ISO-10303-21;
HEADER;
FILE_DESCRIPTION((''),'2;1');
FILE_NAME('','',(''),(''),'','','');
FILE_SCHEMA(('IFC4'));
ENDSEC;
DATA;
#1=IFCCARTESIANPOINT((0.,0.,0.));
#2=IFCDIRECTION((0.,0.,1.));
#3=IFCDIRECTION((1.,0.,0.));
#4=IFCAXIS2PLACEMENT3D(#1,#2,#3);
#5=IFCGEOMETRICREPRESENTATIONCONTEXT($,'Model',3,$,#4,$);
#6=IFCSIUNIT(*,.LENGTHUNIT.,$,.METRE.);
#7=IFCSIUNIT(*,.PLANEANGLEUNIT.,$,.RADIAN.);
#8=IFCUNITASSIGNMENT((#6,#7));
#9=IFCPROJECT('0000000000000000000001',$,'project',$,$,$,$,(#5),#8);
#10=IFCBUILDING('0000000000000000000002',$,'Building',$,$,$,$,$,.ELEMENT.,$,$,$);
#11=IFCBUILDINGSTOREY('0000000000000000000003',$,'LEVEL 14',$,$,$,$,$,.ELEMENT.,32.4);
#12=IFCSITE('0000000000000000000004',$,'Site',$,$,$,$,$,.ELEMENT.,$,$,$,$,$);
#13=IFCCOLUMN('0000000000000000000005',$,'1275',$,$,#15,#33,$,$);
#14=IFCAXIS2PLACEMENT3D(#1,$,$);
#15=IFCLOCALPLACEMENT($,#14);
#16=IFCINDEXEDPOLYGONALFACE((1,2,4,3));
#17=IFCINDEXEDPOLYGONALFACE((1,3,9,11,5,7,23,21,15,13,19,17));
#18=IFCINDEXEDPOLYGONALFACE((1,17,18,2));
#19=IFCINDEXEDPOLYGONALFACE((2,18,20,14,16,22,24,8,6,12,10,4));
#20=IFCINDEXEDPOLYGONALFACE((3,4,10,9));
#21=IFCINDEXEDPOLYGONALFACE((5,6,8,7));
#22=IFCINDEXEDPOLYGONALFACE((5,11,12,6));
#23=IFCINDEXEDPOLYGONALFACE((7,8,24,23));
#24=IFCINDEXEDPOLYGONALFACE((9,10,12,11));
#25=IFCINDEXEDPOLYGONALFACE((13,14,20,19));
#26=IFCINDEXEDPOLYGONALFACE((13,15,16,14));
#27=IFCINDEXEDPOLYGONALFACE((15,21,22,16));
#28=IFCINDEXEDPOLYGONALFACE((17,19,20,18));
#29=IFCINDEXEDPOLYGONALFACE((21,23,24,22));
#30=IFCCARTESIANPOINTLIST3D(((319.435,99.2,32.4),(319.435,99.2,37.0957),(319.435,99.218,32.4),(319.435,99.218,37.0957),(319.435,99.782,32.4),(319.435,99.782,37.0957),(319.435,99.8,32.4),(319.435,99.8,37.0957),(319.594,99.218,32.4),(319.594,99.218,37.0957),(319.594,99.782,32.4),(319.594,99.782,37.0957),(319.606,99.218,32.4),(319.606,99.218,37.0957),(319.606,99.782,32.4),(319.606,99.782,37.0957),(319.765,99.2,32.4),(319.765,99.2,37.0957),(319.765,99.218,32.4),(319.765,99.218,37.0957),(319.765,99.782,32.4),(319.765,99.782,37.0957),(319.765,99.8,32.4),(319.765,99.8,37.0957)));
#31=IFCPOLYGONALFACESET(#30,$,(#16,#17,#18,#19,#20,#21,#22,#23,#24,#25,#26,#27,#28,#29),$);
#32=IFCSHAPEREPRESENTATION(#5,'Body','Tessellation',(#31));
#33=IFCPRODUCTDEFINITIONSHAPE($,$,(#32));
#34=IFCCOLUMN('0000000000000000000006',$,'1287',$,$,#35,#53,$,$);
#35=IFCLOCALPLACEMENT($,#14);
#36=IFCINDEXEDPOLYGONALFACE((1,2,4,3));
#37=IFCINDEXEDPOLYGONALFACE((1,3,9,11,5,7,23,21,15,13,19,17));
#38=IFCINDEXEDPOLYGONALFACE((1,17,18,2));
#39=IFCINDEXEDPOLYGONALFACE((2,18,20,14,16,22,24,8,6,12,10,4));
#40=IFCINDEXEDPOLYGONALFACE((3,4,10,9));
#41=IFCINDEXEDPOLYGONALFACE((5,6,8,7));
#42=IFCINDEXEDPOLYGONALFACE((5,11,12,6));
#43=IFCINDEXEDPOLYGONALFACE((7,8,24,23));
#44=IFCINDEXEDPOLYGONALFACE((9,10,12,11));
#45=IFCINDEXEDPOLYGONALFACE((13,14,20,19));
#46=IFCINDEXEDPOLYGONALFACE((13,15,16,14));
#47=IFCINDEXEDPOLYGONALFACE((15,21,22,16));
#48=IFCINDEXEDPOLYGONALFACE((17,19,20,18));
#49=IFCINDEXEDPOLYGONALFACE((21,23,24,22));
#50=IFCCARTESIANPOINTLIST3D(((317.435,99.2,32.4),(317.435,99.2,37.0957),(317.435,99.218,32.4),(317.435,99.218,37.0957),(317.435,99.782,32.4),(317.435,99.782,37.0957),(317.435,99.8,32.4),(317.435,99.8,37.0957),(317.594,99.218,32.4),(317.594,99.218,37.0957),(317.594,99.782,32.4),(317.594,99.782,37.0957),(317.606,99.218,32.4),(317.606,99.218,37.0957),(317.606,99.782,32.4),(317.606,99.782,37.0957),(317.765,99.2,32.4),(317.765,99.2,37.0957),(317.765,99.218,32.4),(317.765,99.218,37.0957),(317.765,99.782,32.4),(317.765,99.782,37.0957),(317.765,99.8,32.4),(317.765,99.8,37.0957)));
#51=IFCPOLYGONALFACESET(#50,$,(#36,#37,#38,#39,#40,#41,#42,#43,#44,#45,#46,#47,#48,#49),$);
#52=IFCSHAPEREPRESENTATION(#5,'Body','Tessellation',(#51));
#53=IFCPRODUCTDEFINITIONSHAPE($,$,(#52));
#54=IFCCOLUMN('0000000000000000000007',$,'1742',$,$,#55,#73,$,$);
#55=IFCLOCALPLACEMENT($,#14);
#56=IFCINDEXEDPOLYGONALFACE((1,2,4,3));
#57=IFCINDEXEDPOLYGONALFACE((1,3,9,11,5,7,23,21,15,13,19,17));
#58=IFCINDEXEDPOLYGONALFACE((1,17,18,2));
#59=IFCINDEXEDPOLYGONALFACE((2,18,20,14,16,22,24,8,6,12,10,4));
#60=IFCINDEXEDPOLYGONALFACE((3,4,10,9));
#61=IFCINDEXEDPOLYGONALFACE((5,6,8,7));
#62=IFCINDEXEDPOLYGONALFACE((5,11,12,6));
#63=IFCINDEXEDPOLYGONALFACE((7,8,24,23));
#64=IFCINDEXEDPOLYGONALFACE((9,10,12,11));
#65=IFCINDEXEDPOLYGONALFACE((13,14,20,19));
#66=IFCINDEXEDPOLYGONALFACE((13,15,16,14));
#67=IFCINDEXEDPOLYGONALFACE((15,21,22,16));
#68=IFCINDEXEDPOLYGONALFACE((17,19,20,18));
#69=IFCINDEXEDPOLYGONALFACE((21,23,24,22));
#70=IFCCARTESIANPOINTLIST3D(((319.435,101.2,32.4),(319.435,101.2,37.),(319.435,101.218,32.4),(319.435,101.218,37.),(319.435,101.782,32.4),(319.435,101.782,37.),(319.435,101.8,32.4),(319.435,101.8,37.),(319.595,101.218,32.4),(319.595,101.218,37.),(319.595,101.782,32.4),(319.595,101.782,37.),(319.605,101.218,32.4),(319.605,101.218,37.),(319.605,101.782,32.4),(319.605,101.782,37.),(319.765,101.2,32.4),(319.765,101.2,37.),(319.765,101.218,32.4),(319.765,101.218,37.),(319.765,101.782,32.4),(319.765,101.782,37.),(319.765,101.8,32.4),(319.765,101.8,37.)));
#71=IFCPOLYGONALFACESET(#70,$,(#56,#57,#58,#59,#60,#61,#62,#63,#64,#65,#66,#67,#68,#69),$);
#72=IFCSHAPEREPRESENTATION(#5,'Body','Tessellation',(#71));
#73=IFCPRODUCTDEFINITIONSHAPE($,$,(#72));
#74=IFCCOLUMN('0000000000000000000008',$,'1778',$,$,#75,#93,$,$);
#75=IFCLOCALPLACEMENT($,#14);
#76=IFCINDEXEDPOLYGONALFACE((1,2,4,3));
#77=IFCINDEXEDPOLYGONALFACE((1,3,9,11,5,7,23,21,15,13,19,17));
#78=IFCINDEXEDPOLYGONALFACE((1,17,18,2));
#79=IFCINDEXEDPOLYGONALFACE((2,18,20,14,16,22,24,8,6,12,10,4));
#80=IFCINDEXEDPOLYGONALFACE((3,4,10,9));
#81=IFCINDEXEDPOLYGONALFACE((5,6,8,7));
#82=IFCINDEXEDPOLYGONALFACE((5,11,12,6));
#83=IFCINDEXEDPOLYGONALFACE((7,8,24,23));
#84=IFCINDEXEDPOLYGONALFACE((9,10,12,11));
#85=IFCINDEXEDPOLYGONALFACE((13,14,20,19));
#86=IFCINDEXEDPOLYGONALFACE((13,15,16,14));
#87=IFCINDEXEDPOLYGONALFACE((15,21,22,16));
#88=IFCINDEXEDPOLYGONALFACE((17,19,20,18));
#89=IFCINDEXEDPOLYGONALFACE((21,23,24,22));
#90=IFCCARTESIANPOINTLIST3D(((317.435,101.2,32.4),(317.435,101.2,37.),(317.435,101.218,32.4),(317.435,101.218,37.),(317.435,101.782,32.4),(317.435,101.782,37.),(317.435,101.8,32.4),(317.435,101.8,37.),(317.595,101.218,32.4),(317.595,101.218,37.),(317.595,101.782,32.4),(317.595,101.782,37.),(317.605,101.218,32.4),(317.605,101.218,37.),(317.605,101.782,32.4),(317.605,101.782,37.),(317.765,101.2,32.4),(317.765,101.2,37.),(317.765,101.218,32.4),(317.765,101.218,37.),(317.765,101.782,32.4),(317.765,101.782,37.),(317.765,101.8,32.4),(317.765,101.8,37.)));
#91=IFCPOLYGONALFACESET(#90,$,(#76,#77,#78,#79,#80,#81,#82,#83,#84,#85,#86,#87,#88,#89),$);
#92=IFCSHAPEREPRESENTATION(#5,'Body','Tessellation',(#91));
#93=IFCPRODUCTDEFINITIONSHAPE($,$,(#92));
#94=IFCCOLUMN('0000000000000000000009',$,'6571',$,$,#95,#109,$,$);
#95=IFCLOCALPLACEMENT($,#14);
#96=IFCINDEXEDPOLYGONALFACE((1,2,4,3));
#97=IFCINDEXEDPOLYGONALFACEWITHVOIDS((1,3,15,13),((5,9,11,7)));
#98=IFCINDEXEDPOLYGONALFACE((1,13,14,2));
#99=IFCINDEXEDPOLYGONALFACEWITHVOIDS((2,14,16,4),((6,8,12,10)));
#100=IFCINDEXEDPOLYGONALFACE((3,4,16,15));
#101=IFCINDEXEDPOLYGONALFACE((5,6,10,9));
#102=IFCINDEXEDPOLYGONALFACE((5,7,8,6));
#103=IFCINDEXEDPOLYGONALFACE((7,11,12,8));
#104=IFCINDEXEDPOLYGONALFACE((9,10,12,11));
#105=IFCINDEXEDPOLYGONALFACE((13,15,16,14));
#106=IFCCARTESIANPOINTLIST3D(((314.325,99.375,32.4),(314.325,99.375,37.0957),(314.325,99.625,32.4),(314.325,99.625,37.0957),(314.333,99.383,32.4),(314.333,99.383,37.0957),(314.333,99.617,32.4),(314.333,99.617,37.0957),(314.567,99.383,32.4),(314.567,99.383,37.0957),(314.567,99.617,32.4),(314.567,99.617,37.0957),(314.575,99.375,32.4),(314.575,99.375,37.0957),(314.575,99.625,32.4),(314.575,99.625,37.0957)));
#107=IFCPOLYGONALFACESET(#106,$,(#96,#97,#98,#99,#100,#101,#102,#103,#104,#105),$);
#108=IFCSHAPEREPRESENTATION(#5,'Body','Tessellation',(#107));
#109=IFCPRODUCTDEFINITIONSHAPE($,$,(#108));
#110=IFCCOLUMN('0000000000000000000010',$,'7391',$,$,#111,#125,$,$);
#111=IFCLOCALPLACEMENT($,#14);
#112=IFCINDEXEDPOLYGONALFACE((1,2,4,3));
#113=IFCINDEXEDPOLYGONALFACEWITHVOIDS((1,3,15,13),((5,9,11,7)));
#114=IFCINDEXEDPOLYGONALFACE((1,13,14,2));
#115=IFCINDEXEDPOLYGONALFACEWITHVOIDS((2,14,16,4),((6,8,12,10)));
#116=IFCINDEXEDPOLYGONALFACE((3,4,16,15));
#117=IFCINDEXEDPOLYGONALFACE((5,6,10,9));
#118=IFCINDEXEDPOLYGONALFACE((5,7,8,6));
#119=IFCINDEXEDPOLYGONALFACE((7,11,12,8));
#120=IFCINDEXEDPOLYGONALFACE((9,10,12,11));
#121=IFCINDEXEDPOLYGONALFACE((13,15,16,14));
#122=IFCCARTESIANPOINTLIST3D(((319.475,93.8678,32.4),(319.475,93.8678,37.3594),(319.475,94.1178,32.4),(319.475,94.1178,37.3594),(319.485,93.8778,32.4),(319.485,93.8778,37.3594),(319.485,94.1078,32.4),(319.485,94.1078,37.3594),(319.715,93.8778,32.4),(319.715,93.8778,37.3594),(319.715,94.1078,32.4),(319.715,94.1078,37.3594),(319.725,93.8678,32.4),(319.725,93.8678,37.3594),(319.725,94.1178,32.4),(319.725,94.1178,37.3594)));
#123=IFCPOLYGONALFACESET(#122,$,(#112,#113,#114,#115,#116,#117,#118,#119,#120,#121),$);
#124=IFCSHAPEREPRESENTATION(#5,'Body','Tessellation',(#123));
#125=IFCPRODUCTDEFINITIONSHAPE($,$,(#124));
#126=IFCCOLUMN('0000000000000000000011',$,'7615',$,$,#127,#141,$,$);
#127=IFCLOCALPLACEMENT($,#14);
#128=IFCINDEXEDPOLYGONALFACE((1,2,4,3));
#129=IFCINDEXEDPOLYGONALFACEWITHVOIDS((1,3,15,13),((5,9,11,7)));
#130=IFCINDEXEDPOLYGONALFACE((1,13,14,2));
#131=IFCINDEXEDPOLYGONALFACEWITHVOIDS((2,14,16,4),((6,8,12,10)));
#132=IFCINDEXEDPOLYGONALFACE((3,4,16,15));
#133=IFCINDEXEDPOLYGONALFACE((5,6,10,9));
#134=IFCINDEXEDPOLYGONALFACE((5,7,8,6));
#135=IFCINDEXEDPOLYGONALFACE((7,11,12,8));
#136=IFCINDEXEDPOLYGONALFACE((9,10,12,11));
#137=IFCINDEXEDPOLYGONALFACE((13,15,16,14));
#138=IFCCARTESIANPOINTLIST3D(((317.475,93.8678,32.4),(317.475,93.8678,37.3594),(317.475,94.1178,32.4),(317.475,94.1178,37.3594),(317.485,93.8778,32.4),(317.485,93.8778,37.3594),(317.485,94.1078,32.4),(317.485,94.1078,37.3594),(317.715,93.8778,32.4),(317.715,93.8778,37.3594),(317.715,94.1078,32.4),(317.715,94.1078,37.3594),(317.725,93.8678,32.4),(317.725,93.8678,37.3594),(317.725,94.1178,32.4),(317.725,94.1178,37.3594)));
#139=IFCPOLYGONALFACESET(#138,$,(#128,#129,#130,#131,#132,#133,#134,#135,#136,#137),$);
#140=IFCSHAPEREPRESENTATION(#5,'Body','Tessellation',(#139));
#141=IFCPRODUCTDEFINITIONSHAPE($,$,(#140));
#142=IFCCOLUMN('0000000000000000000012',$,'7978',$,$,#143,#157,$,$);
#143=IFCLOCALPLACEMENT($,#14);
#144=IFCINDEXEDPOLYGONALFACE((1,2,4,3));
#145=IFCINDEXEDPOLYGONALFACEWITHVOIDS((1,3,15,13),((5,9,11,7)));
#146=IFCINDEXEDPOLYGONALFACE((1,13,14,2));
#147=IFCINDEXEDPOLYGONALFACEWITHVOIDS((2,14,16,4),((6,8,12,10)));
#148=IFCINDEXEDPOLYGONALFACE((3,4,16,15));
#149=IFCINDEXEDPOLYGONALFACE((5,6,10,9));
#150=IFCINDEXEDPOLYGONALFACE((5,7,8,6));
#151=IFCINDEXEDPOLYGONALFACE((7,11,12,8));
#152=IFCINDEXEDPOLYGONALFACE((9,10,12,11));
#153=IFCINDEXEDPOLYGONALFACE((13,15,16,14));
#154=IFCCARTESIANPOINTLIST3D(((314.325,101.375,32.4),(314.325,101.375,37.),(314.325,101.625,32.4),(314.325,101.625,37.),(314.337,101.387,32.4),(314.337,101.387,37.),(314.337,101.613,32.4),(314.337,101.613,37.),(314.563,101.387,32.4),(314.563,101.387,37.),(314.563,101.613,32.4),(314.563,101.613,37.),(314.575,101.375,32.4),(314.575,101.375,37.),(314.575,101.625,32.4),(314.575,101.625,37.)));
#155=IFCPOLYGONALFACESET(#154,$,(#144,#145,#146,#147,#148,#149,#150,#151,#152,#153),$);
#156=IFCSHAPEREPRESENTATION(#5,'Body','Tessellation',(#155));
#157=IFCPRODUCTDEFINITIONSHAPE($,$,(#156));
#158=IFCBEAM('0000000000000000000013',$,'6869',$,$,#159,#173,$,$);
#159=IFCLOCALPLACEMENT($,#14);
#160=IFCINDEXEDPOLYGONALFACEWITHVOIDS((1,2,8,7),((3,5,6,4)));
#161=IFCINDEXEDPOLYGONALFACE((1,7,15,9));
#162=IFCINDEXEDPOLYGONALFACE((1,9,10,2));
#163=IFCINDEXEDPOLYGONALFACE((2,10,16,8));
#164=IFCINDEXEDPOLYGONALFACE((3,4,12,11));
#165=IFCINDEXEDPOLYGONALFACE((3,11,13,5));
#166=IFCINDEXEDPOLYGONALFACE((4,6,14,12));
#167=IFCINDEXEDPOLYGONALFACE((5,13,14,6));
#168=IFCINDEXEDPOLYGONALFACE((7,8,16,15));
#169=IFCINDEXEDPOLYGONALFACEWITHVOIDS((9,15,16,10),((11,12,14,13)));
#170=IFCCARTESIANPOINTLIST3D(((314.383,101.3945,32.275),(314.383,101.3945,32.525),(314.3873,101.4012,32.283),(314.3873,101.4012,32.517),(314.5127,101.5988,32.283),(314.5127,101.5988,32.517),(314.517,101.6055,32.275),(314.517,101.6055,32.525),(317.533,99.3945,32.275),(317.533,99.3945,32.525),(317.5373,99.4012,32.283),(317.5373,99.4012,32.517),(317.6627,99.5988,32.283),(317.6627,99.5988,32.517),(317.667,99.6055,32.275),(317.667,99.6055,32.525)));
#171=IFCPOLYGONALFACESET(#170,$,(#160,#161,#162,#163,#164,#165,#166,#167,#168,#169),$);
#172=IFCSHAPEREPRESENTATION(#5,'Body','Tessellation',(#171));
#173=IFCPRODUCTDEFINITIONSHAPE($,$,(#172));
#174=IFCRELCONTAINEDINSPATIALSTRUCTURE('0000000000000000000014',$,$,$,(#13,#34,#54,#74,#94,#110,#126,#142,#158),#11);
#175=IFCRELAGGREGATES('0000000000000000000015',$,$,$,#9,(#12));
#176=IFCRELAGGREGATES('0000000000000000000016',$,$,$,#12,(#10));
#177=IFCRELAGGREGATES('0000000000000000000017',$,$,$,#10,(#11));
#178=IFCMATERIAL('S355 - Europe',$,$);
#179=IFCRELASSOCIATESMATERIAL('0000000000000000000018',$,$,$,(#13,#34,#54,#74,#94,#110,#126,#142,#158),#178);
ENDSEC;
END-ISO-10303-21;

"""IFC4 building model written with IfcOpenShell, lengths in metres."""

from ifc_helpers import new_model, si_unit, frame, origin_with_axes, origin_2d_with_axis, place, context, project, spatial, hollow_rectangle, i_section, extrude, material, material_profile, profile_set, profile_usage, element, save


model = new_model("IFC4")

# Units and contexts
model_context = context("Model", 3, world=origin_with_axes())
ifc_project = project(units=[si_unit("LENGTHUNIT", "METRE"), si_unit("PLANEANGLEUNIT", "RADIAN")], contexts=[model_context])

# Site, building, storey
site = spatial("IfcSite", under=ifc_project, Name="Site", CompositionType="ELEMENT")
building = spatial("IfcBuilding", under=site, Name="Building", CompositionType="ELEMENT")
storey = spatial("IfcBuildingStorey", under=building, Name="LEVEL 14", CompositionType="ELEMENT", Elevation=32.4)

# Columns
ifc_material = material(Name="S355 - Europe")
ifc_material_profile_1 = material_profile(ifc_material, i_section(OverallWidth=0.33, OverallDepth=0.6, WebThickness=0.012, FlangeThickness=0.018, at=origin_2d_with_axis()))
ifc_profile_set_1 = profile_set([ifc_material_profile_1])
ifc_profile_usage_1 = profile_usage(ifc_profile_set_1, cardinal=10)
column_1_placement = place(None, frame((319.6, 99.5, 32.4), z_axis=(0.0, 0.0, 1.0), x_axis=(1.0, 0.0, 0.0)))
element("IfcColumn", 1, at=column_1_placement, inside=storey, material=ifc_profile_usage_1, Name="1275", context=model_context, shape_type="SweptSolid", body=[
    extrude(i_section(OverallWidth=0.33, OverallDepth=0.6, WebThickness=0.012, FlangeThickness=0.018, at=origin_2d_with_axis()), origin_with_axes(), (0.0, 0.0, 1.0), 4.6957),
])
ifc_material_profile_2 = material_profile(ifc_material, i_section(OverallWidth=0.33, OverallDepth=0.6, WebThickness=0.012, FlangeThickness=0.018, at=origin_2d_with_axis()))
ifc_profile_set_2 = profile_set([ifc_material_profile_2])
ifc_profile_usage_2 = profile_usage(ifc_profile_set_2, cardinal=10)
column_2_placement = place(None, frame((317.6, 99.5, 32.4), z_axis=(0.0, 0.0, 1.0), x_axis=(1.0, 0.0, 0.0)))
element("IfcColumn", 2, at=column_2_placement, inside=storey, material=ifc_profile_usage_2, Name="1287", context=model_context, shape_type="SweptSolid", body=[
    extrude(i_section(OverallWidth=0.33, OverallDepth=0.6, WebThickness=0.012, FlangeThickness=0.018, at=origin_2d_with_axis()), origin_with_axes(), (0.0, 0.0, 1.0), 4.6957),
])
ifc_material_profile_3 = material_profile(ifc_material, i_section(OverallWidth=0.33, OverallDepth=0.6, WebThickness=0.01, FlangeThickness=0.018, at=origin_2d_with_axis()))
ifc_profile_set_3 = profile_set([ifc_material_profile_3])
ifc_profile_usage_3 = profile_usage(ifc_profile_set_3, cardinal=10)
column_3_placement = place(None, frame((319.6, 101.5, 32.4), z_axis=(0.0, 0.0, 1.0), x_axis=(1.0, 0.0, 0.0)))
element("IfcColumn", 3, at=column_3_placement, inside=storey, material=ifc_profile_usage_3, Name="1742", context=model_context, shape_type="SweptSolid", body=[
    extrude(i_section(OverallWidth=0.33, OverallDepth=0.6, WebThickness=0.01, FlangeThickness=0.018, at=origin_2d_with_axis()), origin_with_axes(), (0.0, 0.0, 1.0), 4.6),
])
ifc_material_profile_4 = material_profile(ifc_material, i_section(OverallWidth=0.33, OverallDepth=0.6, WebThickness=0.01, FlangeThickness=0.018, at=origin_2d_with_axis()))
ifc_profile_set_4 = profile_set([ifc_material_profile_4])
ifc_profile_usage_4 = profile_usage(ifc_profile_set_4, cardinal=10)
column_4_placement = place(None, frame((317.6, 101.5, 32.4), z_axis=(0.0, 0.0, 1.0), x_axis=(1.0, 0.0, 0.0)))
element("IfcColumn", 4, at=column_4_placement, inside=storey, material=ifc_profile_usage_4, Name="1778", context=model_context, shape_type="SweptSolid", body=[
    extrude(i_section(OverallWidth=0.33, OverallDepth=0.6, WebThickness=0.01, FlangeThickness=0.018, at=origin_2d_with_axis()), origin_with_axes(), (0.0, 0.0, 1.0), 4.6),
])
ifc_material_profile_5 = material_profile(ifc_material, hollow_rectangle(XDim=0.25, YDim=0.25, WallThickness=0.008, at=origin_2d_with_axis()))
ifc_profile_set_5 = profile_set([ifc_material_profile_5])
ifc_profile_usage_5 = profile_usage(ifc_profile_set_5, cardinal=10)
column_5_placement = place(None, frame((314.45, 99.5, 32.4), z_axis=(0.0, 0.0, 1.0), x_axis=(0.0, -1.0, 0.0)))
element("IfcColumn", 5, at=column_5_placement, inside=storey, material=ifc_profile_usage_5, Name="6571", context=model_context, shape_type="SweptSolid", body=[
    extrude(hollow_rectangle(XDim=0.25, YDim=0.25, WallThickness=0.008, at=origin_2d_with_axis()), origin_with_axes(), (0.0, 0.0, 1.0), 4.6957),
])
ifc_material_profile_6 = material_profile(ifc_material, hollow_rectangle(XDim=0.25, YDim=0.25, WallThickness=0.01, at=origin_2d_with_axis()))
ifc_profile_set_6 = profile_set([ifc_material_profile_6])
ifc_profile_usage_6 = profile_usage(ifc_profile_set_6, cardinal=10)
column_6_placement = place(None, frame((319.6, 93.9928, 32.4), z_axis=(0.0, 0.0, 1.0), x_axis=(0.0, -1.0, 0.0)))
element("IfcColumn", 6, at=column_6_placement, inside=storey, material=ifc_profile_usage_6, Name="7391", context=model_context, shape_type="SweptSolid", body=[
    extrude(hollow_rectangle(XDim=0.25, YDim=0.25, WallThickness=0.01, at=origin_2d_with_axis()), origin_with_axes(), (0.0, 0.0, 1.0), 4.9594),
])
ifc_material_profile_7 = material_profile(ifc_material, hollow_rectangle(XDim=0.25, YDim=0.25, WallThickness=0.01, at=origin_2d_with_axis()))
ifc_profile_set_7 = profile_set([ifc_material_profile_7])
ifc_profile_usage_7 = profile_usage(ifc_profile_set_7, cardinal=10)
column_7_placement = place(None, frame((317.6, 93.9928, 32.4), z_axis=(0.0, 0.0, 1.0), x_axis=(0.0, -1.0, 0.0)))
element("IfcColumn", 7, at=column_7_placement, inside=storey, material=ifc_profile_usage_7, Name="7615", context=model_context, shape_type="SweptSolid", body=[
    extrude(hollow_rectangle(XDim=0.25, YDim=0.25, WallThickness=0.01, at=origin_2d_with_axis()), origin_with_axes(), (0.0, 0.0, 1.0), 4.9594),
])
ifc_material_profile_8 = material_profile(ifc_material, hollow_rectangle(XDim=0.25, YDim=0.25, WallThickness=0.012, at=origin_2d_with_axis()))
ifc_profile_set_8 = profile_set([ifc_material_profile_8])
ifc_profile_usage_8 = profile_usage(ifc_profile_set_8, cardinal=10)
column_8_placement = place(None, frame((314.45, 101.5, 32.4), z_axis=(0.0, 0.0, 1.0), x_axis=(0.0, -1.0, 0.0)))
element("IfcColumn", 8, at=column_8_placement, inside=storey, material=ifc_profile_usage_8, Name="7978", context=model_context, shape_type="SweptSolid", body=[
    extrude(hollow_rectangle(XDim=0.25, YDim=0.25, WallThickness=0.012, at=origin_2d_with_axis()), origin_with_axes(), (0.0, 0.0, 1.0), 4.6),
])

# Beam
ifc_material_profile_9 = material_profile(ifc_material, hollow_rectangle(XDim=0.25, YDim=0.25, WallThickness=0.008, at=origin_2d_with_axis()))
ifc_profile_set_9 = profile_set([ifc_material_profile_9])
ifc_profile_usage_9 = profile_usage(ifc_profile_set_9, cardinal=10)
beam_1_placement = place(None, frame((317.6, 99.5, 32.4), z_axis=(-0.844213, 0.536008, 0.0), x_axis=(-0.536008, -0.844213, 0.0)))
element("IfcBeam", 9, at=beam_1_placement, inside=storey, material=ifc_profile_usage_9, Name="6869", context=model_context, shape_type="SweptSolid", body=[
    extrude(hollow_rectangle(XDim=0.25, YDim=0.25, WallThickness=0.008, at=origin_2d_with_axis()), origin_with_axes(), (0.0, 0.0, 1.0), 3.7313),
])

save(model, "model.ifc")
